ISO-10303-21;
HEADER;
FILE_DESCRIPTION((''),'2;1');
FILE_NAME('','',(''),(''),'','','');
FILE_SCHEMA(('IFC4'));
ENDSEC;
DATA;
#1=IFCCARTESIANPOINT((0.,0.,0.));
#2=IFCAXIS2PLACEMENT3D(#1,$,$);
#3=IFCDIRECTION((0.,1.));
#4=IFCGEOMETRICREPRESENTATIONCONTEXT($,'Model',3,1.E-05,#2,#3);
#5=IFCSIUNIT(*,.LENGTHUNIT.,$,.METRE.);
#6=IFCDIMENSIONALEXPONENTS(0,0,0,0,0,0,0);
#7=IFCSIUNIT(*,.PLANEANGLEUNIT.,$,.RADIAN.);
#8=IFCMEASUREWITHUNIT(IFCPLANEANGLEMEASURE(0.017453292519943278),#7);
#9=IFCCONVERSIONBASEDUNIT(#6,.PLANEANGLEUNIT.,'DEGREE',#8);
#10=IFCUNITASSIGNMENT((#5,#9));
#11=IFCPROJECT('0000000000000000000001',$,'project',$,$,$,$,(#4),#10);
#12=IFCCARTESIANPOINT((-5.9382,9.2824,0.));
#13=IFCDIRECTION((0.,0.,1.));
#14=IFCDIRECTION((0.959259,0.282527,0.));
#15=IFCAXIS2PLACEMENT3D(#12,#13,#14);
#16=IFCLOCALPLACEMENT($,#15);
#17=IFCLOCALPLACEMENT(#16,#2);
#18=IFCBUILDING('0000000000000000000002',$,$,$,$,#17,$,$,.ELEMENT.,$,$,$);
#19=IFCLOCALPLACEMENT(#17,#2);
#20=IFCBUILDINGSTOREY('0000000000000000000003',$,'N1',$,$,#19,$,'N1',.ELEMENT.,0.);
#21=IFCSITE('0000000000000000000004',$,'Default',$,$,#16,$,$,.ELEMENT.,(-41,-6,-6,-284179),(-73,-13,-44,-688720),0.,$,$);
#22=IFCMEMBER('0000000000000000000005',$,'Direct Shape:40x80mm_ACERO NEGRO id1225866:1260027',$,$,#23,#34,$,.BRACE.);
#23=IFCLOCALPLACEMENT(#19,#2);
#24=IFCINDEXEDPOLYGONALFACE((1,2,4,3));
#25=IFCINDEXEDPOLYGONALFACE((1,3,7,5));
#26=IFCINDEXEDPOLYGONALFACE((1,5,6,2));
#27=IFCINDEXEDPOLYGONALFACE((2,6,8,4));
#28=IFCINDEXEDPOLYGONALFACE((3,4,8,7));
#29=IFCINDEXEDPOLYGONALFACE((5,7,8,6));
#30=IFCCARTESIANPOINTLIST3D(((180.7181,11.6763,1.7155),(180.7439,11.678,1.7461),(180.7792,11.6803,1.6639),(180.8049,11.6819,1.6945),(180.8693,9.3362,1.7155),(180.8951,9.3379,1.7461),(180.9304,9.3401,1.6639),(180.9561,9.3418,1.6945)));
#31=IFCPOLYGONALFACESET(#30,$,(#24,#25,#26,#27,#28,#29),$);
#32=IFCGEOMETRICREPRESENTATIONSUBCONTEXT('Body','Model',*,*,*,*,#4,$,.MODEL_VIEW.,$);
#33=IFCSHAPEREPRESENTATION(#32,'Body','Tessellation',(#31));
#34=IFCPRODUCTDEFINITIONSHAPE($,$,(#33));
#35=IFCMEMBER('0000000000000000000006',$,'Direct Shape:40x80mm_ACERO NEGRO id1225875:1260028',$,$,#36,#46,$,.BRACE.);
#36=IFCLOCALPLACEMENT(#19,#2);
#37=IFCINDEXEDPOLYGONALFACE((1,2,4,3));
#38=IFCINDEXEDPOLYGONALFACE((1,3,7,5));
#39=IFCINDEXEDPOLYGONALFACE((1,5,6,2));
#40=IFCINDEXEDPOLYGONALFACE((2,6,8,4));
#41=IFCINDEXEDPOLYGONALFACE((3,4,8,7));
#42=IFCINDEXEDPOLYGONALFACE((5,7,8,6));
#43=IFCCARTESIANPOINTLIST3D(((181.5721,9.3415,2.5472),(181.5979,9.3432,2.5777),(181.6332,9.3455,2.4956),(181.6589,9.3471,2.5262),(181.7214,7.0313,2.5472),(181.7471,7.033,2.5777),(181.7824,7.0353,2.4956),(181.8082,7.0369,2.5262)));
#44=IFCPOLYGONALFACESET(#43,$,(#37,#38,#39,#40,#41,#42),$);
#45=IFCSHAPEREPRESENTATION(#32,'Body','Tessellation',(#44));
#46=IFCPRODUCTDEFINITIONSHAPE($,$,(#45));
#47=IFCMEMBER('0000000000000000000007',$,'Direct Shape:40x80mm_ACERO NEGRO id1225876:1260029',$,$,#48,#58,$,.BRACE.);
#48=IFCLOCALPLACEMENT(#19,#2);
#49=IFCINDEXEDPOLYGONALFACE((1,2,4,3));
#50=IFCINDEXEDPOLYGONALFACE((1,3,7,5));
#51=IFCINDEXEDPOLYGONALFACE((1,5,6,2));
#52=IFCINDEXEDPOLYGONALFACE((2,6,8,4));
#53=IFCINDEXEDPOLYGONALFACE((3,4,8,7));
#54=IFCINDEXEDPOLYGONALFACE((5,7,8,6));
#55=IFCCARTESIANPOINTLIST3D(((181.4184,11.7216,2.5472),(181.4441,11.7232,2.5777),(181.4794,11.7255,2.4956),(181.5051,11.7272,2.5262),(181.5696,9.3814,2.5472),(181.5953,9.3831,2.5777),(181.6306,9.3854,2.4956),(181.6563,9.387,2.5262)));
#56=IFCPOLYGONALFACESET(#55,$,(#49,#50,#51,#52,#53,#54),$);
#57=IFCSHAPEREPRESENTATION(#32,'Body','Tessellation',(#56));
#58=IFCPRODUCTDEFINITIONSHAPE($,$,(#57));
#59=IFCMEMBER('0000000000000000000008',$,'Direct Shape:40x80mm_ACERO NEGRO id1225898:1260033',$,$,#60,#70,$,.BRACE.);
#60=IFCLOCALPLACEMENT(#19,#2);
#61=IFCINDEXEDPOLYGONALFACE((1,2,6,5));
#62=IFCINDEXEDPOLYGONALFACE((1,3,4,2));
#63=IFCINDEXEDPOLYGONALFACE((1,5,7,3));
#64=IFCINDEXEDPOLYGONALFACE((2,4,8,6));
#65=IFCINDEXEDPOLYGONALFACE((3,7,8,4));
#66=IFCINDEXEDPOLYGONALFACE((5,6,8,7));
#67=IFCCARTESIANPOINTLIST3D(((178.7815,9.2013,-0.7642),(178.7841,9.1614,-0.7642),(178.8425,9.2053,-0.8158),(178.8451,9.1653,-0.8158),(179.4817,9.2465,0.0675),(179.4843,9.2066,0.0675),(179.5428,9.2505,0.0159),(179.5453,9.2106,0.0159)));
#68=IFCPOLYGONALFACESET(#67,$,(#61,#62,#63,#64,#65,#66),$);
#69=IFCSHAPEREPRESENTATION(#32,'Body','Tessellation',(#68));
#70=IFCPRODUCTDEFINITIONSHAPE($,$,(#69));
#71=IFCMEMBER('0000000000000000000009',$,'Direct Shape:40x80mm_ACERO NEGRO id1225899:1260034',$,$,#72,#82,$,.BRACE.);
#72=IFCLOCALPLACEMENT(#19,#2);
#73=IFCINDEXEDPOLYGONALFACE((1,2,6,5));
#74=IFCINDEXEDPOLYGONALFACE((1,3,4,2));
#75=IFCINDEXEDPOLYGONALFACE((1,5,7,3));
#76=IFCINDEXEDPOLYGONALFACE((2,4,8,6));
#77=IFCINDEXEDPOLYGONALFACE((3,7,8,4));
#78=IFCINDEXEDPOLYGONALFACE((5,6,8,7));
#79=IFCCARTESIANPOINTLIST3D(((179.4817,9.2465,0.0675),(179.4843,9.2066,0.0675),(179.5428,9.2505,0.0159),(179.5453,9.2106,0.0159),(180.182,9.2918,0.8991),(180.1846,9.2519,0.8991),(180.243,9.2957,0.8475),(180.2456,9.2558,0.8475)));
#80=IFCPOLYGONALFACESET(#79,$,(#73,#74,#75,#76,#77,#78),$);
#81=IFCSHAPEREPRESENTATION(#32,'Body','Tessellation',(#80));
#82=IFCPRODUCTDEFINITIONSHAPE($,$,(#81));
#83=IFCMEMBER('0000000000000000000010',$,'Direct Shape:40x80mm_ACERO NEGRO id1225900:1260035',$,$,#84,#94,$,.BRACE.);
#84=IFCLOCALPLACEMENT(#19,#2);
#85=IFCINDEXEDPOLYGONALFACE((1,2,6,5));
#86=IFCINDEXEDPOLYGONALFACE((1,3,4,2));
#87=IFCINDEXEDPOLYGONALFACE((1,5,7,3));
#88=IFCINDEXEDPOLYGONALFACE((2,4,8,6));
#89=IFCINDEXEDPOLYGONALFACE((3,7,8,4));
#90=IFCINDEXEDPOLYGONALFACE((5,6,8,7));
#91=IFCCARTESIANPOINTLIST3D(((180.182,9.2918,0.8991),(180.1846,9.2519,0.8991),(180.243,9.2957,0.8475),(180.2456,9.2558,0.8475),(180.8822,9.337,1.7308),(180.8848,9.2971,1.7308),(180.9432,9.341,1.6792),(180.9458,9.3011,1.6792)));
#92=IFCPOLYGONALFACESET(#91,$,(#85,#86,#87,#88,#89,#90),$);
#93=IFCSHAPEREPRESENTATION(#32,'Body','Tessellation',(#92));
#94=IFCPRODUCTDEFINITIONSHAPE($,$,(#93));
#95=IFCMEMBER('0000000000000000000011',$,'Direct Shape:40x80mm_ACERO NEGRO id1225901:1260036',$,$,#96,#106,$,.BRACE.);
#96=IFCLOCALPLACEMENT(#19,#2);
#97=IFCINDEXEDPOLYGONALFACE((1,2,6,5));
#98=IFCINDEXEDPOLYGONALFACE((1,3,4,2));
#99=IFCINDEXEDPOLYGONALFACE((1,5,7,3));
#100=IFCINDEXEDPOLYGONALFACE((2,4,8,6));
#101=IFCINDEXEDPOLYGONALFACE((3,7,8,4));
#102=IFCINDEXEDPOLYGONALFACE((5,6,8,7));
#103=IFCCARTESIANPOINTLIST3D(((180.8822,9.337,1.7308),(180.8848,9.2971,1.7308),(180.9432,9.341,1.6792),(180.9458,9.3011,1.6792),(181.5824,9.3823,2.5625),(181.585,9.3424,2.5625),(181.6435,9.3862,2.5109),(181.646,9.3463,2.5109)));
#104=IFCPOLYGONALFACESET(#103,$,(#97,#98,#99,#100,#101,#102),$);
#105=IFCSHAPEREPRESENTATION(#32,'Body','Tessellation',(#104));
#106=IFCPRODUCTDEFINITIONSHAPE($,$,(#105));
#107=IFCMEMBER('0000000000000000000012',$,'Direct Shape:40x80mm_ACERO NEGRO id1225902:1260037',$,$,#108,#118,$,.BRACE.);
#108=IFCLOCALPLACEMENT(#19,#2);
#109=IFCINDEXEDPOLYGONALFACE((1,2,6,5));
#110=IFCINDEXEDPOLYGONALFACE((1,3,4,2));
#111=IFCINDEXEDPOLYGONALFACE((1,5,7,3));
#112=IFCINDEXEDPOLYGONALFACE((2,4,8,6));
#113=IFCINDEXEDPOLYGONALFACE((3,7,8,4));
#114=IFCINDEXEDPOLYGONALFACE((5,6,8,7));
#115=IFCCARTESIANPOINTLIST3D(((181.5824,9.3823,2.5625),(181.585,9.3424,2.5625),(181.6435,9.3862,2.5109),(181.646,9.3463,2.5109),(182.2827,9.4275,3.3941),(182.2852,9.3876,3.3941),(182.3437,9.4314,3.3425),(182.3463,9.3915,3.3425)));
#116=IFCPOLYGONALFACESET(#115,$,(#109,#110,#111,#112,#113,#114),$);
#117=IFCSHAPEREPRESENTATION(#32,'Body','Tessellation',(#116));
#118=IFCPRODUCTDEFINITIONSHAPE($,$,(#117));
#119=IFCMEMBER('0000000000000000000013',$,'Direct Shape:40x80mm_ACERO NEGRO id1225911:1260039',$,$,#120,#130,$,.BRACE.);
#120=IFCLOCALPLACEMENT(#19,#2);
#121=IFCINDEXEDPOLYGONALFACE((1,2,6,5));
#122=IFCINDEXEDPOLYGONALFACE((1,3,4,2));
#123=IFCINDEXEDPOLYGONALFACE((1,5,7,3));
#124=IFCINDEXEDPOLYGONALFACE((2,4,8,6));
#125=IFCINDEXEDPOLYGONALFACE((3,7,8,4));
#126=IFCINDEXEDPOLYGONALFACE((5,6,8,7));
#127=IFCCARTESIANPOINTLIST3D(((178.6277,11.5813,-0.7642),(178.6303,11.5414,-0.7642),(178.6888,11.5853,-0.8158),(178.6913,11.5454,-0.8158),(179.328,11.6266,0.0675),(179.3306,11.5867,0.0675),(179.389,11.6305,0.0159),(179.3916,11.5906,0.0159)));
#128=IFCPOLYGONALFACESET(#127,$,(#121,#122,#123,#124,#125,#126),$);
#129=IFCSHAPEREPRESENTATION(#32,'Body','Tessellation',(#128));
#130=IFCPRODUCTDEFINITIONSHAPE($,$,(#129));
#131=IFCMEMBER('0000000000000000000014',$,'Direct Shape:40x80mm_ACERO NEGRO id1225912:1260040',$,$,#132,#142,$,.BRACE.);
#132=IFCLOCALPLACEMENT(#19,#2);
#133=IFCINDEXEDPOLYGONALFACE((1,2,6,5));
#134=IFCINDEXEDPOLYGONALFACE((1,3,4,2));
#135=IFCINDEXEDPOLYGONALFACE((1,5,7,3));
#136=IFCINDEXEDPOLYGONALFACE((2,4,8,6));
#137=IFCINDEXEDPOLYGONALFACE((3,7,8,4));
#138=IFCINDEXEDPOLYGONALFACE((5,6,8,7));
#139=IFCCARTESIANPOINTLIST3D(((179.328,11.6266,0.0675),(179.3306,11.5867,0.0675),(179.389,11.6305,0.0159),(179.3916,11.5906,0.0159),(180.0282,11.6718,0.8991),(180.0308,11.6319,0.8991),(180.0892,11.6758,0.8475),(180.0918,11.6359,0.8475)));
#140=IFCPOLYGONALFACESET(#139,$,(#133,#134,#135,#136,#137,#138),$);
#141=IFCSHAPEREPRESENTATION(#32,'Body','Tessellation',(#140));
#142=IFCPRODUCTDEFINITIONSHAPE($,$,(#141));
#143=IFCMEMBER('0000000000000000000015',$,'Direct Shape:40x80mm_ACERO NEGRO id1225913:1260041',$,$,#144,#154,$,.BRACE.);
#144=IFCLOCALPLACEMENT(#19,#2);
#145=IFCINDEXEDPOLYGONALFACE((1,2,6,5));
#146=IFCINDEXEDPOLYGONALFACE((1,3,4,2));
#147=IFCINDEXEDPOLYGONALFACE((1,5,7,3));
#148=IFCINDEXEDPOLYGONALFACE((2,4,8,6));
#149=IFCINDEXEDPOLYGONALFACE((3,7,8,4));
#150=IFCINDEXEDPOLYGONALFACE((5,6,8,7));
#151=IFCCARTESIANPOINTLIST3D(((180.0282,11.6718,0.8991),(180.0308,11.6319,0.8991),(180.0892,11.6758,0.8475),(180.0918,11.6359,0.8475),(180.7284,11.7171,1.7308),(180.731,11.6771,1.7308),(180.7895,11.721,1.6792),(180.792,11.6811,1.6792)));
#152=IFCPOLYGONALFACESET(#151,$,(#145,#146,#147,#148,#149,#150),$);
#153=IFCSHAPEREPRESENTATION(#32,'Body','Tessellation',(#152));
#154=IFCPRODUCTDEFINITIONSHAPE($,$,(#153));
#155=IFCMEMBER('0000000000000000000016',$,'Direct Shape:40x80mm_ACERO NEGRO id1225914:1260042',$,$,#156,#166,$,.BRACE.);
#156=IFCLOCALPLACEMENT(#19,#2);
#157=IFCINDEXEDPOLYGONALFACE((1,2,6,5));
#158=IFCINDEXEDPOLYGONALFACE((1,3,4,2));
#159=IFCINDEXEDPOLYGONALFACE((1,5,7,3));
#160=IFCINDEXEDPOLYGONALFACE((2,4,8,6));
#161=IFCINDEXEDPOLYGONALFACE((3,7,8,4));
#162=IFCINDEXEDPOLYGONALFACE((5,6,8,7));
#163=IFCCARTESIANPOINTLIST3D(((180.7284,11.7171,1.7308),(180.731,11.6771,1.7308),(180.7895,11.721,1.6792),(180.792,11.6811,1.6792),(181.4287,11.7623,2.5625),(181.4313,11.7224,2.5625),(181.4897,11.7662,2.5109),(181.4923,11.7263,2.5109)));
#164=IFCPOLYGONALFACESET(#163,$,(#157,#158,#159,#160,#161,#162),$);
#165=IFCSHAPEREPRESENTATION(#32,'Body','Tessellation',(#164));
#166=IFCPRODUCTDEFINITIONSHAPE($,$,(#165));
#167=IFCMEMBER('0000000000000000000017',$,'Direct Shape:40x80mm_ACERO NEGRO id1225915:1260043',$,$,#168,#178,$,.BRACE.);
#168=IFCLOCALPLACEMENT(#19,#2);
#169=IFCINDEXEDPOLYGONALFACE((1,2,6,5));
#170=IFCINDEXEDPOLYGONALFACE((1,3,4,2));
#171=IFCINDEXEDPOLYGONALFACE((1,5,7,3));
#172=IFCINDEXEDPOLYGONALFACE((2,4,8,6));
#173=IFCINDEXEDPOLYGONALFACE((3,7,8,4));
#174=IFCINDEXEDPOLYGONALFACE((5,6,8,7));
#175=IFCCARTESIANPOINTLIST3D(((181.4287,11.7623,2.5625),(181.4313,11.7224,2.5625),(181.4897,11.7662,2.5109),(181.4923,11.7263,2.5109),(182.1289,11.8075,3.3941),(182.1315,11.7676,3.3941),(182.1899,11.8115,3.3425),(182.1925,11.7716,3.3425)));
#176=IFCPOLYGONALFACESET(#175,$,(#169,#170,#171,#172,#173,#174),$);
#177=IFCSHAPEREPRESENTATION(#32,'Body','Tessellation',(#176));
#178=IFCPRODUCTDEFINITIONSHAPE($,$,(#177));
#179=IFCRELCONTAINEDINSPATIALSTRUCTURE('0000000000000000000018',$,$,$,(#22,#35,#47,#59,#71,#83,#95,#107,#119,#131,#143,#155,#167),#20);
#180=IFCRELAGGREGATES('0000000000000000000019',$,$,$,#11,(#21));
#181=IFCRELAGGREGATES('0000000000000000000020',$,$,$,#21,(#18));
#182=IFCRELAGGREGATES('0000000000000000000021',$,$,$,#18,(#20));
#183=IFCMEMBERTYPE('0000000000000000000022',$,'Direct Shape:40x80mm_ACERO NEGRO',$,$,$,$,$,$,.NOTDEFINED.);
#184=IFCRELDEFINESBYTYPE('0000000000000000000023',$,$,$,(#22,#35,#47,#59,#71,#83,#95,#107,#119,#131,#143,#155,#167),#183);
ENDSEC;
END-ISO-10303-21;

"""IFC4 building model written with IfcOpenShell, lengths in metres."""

from ifc_helpers import new_model, entity, si_unit, converted_unit, direction, frame, frame_2d, origin, place, context, subcontext, project, spatial, rectangle, extrude, type_object, element, save


model = new_model("IFC4")

# Units and contexts
model_context = context("Model", 3, precision=1e-05, world=origin(), true_north=direction((0.0, 1.0)))
body_context = subcontext(model_context, "Body", "Model", "MODEL_VIEW")
ifc_project = project(units=[si_unit("LENGTHUNIT", "METRE"), converted_unit("PLANEANGLEUNIT", "DEGREE", entity("IfcPlaneAngleMeasure", 0.017453292519943278), si_unit("PLANEANGLEUNIT", "RADIAN"), dimensions=[0, 0, 0, 0, 0, 0, 0])], contexts=[model_context])

# Site, building, storey
site_placement = place(None, frame((-5.9382, 9.2824, 0.0), z_axis=(0.0, 0.0, 1.0), x_axis=(0.959259, 0.282527, 0.0)))
site = spatial("IfcSite", under=ifc_project, at=site_placement, Name="Default", CompositionType="ELEMENT", RefLatitude=(-41, -6, -6, -284179), RefLongitude=(-73, -13, -44, -688720), RefElevation=0.0)
building_placement = place(site_placement, origin())
building = spatial("IfcBuilding", under=site, at=building_placement, CompositionType="ELEMENT")
storey_placement = place(building_placement, origin())
storey = spatial("IfcBuildingStorey", under=building, at=storey_placement, Name="N1", LongName="N1", CompositionType="ELEMENT", Elevation=0.0)

# Members
member_type = type_object("IfcMemberType", Name="Direct Shape:40x80mm_ACERO NEGRO", PredefinedType="NOTDEFINED")
member_1_placement = place(storey_placement, origin())
element("IfcMember", 1, at=member_1_placement, inside=storey, type_object=member_type, Name="Direct Shape:40x80mm_ACERO NEGRO id1225866:1260027", PredefinedType="BRACE", context=body_context, shape_type="SweptSolid", body=[
    extrude(rectangle(XDim=0.04, YDim=0.08, at=frame_2d((0.0, 0.0), x_axis=(0.0, 1.0))), frame((180.9127, 9.339, 1.705), z_axis=(-0.064471, 0.99792, 0.0), x_axis=(0.762714, 0.049276, -0.644857)), (0.0, 0.0, 1.0), 2.345),
])
member_2_placement = place(storey_placement, origin())
element("IfcMember", 2, at=member_2_placement, inside=storey, type_object=member_type, Name="Direct Shape:40x80mm_ACERO NEGRO id1225875:1260028", PredefinedType="BRACE", context=body_context, shape_type="SweptSolid", body=[
    extrude(rectangle(XDim=0.04, YDim=0.08, at=frame_2d((0.0, 0.0), x_axis=(0.0, 1.0))), frame((181.7648, 7.0341, 2.5367), z_axis=(-0.064471, 0.99792, 0.0), x_axis=(0.762714, 0.049276, -0.644857)), (0.0, 0.0, 1.0), 2.315),
])
member_3_placement = place(storey_placement, origin())
element("IfcMember", 3, at=member_3_placement, inside=storey, type_object=member_type, Name="Direct Shape:40x80mm_ACERO NEGRO id1225876:1260029", PredefinedType="BRACE", context=body_context, shape_type="SweptSolid", body=[
    extrude(rectangle(XDim=0.04, YDim=0.08, at=frame_2d((0.0, 0.0), x_axis=(0.0, 1.0))), frame((181.6129, 9.3842, 2.5367), z_axis=(-0.064471, 0.99792, 0.0), x_axis=(0.762714, 0.049276, -0.644857)), (0.0, 0.0, 1.0), 2.345),
])
member_4_placement = place(storey_placement, origin())
element("IfcMember", 4, at=member_4_placement, inside=storey, type_object=member_type, Name="Direct Shape:40x80mm_ACERO NEGRO id1225898:1260033", PredefinedType="BRACE", context=body_context, shape_type="SweptSolid", body=[
    extrude(rectangle(XDim=0.08, YDim=0.04, at=frame_2d((0.0, 0.0), x_axis=(0.0, 1.0))), frame((178.8133, 9.1833, -0.79), z_axis=(0.643515, 0.041575, 0.764304), x_axis=(0.064471, -0.99792, 0.0)), (0.0, 0.0, 1.0), 1.0881),
])
member_5_placement = place(storey_placement, origin())
element("IfcMember", 5, at=member_5_placement, inside=storey, type_object=member_type, Name="Direct Shape:40x80mm_ACERO NEGRO id1225899:1260034", PredefinedType="BRACE", context=body_context, shape_type="SweptSolid", body=[
    extrude(rectangle(XDim=0.08, YDim=0.04, at=frame_2d((0.0, 0.0), x_axis=(0.0, 1.0))), frame((179.5135, 9.2286, 0.0417), z_axis=(0.643515, 0.041575, 0.764304), x_axis=(0.064471, -0.99792, 0.0)), (0.0, 0.0, 1.0), 1.0881),
])
member_6_placement = place(storey_placement, origin())
element("IfcMember", 6, at=member_6_placement, inside=storey, type_object=member_type, Name="Direct Shape:40x80mm_ACERO NEGRO id1225900:1260035", PredefinedType="BRACE", context=body_context, shape_type="SweptSolid", body=[
    extrude(rectangle(XDim=0.08, YDim=0.04, at=frame_2d((0.0, 0.0), x_axis=(0.0, 1.0))), frame((180.2138, 9.2738, 0.8733), z_axis=(0.643515, 0.041575, 0.764304), x_axis=(0.064471, -0.99792, 0.0)), (0.0, 0.0, 1.0), 1.0881),
])
member_7_placement = place(storey_placement, origin())
element("IfcMember", 7, at=member_7_placement, inside=storey, type_object=member_type, Name="Direct Shape:40x80mm_ACERO NEGRO id1225901:1260036", PredefinedType="BRACE", context=body_context, shape_type="SweptSolid", body=[
    extrude(rectangle(XDim=0.08, YDim=0.04, at=frame_2d((0.0, 0.0), x_axis=(0.0, 1.0))), frame((180.914, 9.319, 1.705), z_axis=(0.643515, 0.041575, 0.764304), x_axis=(0.064471, -0.99792, 0.0)), (0.0, 0.0, 1.0), 1.0881),
])
member_8_placement = place(storey_placement, origin())
element("IfcMember", 8, at=member_8_placement, inside=storey, type_object=member_type, Name="Direct Shape:40x80mm_ACERO NEGRO id1225902:1260037", PredefinedType="BRACE", context=body_context, shape_type="SweptSolid", body=[
    extrude(rectangle(XDim=0.08, YDim=0.04, at=frame_2d((0.0, 0.0), x_axis=(0.0, 1.0))), frame((181.6142, 9.3643, 2.5367), z_axis=(0.643515, 0.041575, 0.764304), x_axis=(0.064471, -0.99792, 0.0)), (0.0, 0.0, 1.0), 1.0881),
])
member_9_placement = place(storey_placement, origin())
element("IfcMember", 9, at=member_9_placement, inside=storey, type_object=member_type, Name="Direct Shape:40x80mm_ACERO NEGRO id1225911:1260039", PredefinedType="BRACE", context=body_context, shape_type="SweptSolid", body=[
    extrude(rectangle(XDim=0.08, YDim=0.04, at=frame_2d((0.0, 0.0), x_axis=(0.0, 1.0))), frame((178.6595, 11.5634, -0.79), z_axis=(0.643515, 0.041575, 0.764304), x_axis=(0.064471, -0.99792, 0.0)), (0.0, 0.0, 1.0), 1.0881),
])
member_10_placement = place(storey_placement, origin())
element("IfcMember", 10, at=member_10_placement, inside=storey, type_object=member_type, Name="Direct Shape:40x80mm_ACERO NEGRO id1225912:1260040", PredefinedType="BRACE", context=body_context, shape_type="SweptSolid", body=[
    extrude(rectangle(XDim=0.08, YDim=0.04, at=frame_2d((0.0, 0.0), x_axis=(0.0, 1.0))), frame((179.3598, 11.6086, 0.0417), z_axis=(0.643515, 0.041575, 0.764304), x_axis=(0.064471, -0.99792, 0.0)), (0.0, 0.0, 1.0), 1.0881),
])
member_11_placement = place(storey_placement, origin())
element("IfcMember", 11, at=member_11_placement, inside=storey, type_object=member_type, Name="Direct Shape:40x80mm_ACERO NEGRO id1225913:1260041", PredefinedType="BRACE", context=body_context, shape_type="SweptSolid", body=[
    extrude(rectangle(XDim=0.08, YDim=0.04, at=frame_2d((0.0, 0.0), x_axis=(0.0, 1.0))), frame((180.06, 11.6538, 0.8733), z_axis=(0.643515, 0.041575, 0.764304), x_axis=(0.064471, -0.99792, 0.0)), (0.0, 0.0, 1.0), 1.0881),
])
member_12_placement = place(storey_placement, origin())
element("IfcMember", 12, at=member_12_placement, inside=storey, type_object=member_type, Name="Direct Shape:40x80mm_ACERO NEGRO id1225914:1260042", PredefinedType="BRACE", context=body_context, shape_type="SweptSolid", body=[
    extrude(rectangle(XDim=0.08, YDim=0.04, at=frame_2d((0.0, 0.0), x_axis=(0.0, 1.0))), frame((180.7602, 11.6991, 1.705), z_axis=(0.643515, 0.041575, 0.764304), x_axis=(0.064471, -0.99792, 0.0)), (0.0, 0.0, 1.0), 1.0881),
])
member_13_placement = place(storey_placement, origin())
element("IfcMember", 13, at=member_13_placement, inside=storey, type_object=member_type, Name="Direct Shape:40x80mm_ACERO NEGRO id1225915:1260043", PredefinedType="BRACE", context=body_context, shape_type="SweptSolid", body=[
    extrude(rectangle(XDim=0.08, YDim=0.04, at=frame_2d((0.0, 0.0), x_axis=(0.0, 1.0))), frame((181.4605, 11.7443, 2.5367), z_axis=(0.643515, 0.041575, 0.764304), x_axis=(0.064471, -0.99792, 0.0)), (0.0, 0.0, 1.0), 1.0881),
])

save(model, "model.ifc")
